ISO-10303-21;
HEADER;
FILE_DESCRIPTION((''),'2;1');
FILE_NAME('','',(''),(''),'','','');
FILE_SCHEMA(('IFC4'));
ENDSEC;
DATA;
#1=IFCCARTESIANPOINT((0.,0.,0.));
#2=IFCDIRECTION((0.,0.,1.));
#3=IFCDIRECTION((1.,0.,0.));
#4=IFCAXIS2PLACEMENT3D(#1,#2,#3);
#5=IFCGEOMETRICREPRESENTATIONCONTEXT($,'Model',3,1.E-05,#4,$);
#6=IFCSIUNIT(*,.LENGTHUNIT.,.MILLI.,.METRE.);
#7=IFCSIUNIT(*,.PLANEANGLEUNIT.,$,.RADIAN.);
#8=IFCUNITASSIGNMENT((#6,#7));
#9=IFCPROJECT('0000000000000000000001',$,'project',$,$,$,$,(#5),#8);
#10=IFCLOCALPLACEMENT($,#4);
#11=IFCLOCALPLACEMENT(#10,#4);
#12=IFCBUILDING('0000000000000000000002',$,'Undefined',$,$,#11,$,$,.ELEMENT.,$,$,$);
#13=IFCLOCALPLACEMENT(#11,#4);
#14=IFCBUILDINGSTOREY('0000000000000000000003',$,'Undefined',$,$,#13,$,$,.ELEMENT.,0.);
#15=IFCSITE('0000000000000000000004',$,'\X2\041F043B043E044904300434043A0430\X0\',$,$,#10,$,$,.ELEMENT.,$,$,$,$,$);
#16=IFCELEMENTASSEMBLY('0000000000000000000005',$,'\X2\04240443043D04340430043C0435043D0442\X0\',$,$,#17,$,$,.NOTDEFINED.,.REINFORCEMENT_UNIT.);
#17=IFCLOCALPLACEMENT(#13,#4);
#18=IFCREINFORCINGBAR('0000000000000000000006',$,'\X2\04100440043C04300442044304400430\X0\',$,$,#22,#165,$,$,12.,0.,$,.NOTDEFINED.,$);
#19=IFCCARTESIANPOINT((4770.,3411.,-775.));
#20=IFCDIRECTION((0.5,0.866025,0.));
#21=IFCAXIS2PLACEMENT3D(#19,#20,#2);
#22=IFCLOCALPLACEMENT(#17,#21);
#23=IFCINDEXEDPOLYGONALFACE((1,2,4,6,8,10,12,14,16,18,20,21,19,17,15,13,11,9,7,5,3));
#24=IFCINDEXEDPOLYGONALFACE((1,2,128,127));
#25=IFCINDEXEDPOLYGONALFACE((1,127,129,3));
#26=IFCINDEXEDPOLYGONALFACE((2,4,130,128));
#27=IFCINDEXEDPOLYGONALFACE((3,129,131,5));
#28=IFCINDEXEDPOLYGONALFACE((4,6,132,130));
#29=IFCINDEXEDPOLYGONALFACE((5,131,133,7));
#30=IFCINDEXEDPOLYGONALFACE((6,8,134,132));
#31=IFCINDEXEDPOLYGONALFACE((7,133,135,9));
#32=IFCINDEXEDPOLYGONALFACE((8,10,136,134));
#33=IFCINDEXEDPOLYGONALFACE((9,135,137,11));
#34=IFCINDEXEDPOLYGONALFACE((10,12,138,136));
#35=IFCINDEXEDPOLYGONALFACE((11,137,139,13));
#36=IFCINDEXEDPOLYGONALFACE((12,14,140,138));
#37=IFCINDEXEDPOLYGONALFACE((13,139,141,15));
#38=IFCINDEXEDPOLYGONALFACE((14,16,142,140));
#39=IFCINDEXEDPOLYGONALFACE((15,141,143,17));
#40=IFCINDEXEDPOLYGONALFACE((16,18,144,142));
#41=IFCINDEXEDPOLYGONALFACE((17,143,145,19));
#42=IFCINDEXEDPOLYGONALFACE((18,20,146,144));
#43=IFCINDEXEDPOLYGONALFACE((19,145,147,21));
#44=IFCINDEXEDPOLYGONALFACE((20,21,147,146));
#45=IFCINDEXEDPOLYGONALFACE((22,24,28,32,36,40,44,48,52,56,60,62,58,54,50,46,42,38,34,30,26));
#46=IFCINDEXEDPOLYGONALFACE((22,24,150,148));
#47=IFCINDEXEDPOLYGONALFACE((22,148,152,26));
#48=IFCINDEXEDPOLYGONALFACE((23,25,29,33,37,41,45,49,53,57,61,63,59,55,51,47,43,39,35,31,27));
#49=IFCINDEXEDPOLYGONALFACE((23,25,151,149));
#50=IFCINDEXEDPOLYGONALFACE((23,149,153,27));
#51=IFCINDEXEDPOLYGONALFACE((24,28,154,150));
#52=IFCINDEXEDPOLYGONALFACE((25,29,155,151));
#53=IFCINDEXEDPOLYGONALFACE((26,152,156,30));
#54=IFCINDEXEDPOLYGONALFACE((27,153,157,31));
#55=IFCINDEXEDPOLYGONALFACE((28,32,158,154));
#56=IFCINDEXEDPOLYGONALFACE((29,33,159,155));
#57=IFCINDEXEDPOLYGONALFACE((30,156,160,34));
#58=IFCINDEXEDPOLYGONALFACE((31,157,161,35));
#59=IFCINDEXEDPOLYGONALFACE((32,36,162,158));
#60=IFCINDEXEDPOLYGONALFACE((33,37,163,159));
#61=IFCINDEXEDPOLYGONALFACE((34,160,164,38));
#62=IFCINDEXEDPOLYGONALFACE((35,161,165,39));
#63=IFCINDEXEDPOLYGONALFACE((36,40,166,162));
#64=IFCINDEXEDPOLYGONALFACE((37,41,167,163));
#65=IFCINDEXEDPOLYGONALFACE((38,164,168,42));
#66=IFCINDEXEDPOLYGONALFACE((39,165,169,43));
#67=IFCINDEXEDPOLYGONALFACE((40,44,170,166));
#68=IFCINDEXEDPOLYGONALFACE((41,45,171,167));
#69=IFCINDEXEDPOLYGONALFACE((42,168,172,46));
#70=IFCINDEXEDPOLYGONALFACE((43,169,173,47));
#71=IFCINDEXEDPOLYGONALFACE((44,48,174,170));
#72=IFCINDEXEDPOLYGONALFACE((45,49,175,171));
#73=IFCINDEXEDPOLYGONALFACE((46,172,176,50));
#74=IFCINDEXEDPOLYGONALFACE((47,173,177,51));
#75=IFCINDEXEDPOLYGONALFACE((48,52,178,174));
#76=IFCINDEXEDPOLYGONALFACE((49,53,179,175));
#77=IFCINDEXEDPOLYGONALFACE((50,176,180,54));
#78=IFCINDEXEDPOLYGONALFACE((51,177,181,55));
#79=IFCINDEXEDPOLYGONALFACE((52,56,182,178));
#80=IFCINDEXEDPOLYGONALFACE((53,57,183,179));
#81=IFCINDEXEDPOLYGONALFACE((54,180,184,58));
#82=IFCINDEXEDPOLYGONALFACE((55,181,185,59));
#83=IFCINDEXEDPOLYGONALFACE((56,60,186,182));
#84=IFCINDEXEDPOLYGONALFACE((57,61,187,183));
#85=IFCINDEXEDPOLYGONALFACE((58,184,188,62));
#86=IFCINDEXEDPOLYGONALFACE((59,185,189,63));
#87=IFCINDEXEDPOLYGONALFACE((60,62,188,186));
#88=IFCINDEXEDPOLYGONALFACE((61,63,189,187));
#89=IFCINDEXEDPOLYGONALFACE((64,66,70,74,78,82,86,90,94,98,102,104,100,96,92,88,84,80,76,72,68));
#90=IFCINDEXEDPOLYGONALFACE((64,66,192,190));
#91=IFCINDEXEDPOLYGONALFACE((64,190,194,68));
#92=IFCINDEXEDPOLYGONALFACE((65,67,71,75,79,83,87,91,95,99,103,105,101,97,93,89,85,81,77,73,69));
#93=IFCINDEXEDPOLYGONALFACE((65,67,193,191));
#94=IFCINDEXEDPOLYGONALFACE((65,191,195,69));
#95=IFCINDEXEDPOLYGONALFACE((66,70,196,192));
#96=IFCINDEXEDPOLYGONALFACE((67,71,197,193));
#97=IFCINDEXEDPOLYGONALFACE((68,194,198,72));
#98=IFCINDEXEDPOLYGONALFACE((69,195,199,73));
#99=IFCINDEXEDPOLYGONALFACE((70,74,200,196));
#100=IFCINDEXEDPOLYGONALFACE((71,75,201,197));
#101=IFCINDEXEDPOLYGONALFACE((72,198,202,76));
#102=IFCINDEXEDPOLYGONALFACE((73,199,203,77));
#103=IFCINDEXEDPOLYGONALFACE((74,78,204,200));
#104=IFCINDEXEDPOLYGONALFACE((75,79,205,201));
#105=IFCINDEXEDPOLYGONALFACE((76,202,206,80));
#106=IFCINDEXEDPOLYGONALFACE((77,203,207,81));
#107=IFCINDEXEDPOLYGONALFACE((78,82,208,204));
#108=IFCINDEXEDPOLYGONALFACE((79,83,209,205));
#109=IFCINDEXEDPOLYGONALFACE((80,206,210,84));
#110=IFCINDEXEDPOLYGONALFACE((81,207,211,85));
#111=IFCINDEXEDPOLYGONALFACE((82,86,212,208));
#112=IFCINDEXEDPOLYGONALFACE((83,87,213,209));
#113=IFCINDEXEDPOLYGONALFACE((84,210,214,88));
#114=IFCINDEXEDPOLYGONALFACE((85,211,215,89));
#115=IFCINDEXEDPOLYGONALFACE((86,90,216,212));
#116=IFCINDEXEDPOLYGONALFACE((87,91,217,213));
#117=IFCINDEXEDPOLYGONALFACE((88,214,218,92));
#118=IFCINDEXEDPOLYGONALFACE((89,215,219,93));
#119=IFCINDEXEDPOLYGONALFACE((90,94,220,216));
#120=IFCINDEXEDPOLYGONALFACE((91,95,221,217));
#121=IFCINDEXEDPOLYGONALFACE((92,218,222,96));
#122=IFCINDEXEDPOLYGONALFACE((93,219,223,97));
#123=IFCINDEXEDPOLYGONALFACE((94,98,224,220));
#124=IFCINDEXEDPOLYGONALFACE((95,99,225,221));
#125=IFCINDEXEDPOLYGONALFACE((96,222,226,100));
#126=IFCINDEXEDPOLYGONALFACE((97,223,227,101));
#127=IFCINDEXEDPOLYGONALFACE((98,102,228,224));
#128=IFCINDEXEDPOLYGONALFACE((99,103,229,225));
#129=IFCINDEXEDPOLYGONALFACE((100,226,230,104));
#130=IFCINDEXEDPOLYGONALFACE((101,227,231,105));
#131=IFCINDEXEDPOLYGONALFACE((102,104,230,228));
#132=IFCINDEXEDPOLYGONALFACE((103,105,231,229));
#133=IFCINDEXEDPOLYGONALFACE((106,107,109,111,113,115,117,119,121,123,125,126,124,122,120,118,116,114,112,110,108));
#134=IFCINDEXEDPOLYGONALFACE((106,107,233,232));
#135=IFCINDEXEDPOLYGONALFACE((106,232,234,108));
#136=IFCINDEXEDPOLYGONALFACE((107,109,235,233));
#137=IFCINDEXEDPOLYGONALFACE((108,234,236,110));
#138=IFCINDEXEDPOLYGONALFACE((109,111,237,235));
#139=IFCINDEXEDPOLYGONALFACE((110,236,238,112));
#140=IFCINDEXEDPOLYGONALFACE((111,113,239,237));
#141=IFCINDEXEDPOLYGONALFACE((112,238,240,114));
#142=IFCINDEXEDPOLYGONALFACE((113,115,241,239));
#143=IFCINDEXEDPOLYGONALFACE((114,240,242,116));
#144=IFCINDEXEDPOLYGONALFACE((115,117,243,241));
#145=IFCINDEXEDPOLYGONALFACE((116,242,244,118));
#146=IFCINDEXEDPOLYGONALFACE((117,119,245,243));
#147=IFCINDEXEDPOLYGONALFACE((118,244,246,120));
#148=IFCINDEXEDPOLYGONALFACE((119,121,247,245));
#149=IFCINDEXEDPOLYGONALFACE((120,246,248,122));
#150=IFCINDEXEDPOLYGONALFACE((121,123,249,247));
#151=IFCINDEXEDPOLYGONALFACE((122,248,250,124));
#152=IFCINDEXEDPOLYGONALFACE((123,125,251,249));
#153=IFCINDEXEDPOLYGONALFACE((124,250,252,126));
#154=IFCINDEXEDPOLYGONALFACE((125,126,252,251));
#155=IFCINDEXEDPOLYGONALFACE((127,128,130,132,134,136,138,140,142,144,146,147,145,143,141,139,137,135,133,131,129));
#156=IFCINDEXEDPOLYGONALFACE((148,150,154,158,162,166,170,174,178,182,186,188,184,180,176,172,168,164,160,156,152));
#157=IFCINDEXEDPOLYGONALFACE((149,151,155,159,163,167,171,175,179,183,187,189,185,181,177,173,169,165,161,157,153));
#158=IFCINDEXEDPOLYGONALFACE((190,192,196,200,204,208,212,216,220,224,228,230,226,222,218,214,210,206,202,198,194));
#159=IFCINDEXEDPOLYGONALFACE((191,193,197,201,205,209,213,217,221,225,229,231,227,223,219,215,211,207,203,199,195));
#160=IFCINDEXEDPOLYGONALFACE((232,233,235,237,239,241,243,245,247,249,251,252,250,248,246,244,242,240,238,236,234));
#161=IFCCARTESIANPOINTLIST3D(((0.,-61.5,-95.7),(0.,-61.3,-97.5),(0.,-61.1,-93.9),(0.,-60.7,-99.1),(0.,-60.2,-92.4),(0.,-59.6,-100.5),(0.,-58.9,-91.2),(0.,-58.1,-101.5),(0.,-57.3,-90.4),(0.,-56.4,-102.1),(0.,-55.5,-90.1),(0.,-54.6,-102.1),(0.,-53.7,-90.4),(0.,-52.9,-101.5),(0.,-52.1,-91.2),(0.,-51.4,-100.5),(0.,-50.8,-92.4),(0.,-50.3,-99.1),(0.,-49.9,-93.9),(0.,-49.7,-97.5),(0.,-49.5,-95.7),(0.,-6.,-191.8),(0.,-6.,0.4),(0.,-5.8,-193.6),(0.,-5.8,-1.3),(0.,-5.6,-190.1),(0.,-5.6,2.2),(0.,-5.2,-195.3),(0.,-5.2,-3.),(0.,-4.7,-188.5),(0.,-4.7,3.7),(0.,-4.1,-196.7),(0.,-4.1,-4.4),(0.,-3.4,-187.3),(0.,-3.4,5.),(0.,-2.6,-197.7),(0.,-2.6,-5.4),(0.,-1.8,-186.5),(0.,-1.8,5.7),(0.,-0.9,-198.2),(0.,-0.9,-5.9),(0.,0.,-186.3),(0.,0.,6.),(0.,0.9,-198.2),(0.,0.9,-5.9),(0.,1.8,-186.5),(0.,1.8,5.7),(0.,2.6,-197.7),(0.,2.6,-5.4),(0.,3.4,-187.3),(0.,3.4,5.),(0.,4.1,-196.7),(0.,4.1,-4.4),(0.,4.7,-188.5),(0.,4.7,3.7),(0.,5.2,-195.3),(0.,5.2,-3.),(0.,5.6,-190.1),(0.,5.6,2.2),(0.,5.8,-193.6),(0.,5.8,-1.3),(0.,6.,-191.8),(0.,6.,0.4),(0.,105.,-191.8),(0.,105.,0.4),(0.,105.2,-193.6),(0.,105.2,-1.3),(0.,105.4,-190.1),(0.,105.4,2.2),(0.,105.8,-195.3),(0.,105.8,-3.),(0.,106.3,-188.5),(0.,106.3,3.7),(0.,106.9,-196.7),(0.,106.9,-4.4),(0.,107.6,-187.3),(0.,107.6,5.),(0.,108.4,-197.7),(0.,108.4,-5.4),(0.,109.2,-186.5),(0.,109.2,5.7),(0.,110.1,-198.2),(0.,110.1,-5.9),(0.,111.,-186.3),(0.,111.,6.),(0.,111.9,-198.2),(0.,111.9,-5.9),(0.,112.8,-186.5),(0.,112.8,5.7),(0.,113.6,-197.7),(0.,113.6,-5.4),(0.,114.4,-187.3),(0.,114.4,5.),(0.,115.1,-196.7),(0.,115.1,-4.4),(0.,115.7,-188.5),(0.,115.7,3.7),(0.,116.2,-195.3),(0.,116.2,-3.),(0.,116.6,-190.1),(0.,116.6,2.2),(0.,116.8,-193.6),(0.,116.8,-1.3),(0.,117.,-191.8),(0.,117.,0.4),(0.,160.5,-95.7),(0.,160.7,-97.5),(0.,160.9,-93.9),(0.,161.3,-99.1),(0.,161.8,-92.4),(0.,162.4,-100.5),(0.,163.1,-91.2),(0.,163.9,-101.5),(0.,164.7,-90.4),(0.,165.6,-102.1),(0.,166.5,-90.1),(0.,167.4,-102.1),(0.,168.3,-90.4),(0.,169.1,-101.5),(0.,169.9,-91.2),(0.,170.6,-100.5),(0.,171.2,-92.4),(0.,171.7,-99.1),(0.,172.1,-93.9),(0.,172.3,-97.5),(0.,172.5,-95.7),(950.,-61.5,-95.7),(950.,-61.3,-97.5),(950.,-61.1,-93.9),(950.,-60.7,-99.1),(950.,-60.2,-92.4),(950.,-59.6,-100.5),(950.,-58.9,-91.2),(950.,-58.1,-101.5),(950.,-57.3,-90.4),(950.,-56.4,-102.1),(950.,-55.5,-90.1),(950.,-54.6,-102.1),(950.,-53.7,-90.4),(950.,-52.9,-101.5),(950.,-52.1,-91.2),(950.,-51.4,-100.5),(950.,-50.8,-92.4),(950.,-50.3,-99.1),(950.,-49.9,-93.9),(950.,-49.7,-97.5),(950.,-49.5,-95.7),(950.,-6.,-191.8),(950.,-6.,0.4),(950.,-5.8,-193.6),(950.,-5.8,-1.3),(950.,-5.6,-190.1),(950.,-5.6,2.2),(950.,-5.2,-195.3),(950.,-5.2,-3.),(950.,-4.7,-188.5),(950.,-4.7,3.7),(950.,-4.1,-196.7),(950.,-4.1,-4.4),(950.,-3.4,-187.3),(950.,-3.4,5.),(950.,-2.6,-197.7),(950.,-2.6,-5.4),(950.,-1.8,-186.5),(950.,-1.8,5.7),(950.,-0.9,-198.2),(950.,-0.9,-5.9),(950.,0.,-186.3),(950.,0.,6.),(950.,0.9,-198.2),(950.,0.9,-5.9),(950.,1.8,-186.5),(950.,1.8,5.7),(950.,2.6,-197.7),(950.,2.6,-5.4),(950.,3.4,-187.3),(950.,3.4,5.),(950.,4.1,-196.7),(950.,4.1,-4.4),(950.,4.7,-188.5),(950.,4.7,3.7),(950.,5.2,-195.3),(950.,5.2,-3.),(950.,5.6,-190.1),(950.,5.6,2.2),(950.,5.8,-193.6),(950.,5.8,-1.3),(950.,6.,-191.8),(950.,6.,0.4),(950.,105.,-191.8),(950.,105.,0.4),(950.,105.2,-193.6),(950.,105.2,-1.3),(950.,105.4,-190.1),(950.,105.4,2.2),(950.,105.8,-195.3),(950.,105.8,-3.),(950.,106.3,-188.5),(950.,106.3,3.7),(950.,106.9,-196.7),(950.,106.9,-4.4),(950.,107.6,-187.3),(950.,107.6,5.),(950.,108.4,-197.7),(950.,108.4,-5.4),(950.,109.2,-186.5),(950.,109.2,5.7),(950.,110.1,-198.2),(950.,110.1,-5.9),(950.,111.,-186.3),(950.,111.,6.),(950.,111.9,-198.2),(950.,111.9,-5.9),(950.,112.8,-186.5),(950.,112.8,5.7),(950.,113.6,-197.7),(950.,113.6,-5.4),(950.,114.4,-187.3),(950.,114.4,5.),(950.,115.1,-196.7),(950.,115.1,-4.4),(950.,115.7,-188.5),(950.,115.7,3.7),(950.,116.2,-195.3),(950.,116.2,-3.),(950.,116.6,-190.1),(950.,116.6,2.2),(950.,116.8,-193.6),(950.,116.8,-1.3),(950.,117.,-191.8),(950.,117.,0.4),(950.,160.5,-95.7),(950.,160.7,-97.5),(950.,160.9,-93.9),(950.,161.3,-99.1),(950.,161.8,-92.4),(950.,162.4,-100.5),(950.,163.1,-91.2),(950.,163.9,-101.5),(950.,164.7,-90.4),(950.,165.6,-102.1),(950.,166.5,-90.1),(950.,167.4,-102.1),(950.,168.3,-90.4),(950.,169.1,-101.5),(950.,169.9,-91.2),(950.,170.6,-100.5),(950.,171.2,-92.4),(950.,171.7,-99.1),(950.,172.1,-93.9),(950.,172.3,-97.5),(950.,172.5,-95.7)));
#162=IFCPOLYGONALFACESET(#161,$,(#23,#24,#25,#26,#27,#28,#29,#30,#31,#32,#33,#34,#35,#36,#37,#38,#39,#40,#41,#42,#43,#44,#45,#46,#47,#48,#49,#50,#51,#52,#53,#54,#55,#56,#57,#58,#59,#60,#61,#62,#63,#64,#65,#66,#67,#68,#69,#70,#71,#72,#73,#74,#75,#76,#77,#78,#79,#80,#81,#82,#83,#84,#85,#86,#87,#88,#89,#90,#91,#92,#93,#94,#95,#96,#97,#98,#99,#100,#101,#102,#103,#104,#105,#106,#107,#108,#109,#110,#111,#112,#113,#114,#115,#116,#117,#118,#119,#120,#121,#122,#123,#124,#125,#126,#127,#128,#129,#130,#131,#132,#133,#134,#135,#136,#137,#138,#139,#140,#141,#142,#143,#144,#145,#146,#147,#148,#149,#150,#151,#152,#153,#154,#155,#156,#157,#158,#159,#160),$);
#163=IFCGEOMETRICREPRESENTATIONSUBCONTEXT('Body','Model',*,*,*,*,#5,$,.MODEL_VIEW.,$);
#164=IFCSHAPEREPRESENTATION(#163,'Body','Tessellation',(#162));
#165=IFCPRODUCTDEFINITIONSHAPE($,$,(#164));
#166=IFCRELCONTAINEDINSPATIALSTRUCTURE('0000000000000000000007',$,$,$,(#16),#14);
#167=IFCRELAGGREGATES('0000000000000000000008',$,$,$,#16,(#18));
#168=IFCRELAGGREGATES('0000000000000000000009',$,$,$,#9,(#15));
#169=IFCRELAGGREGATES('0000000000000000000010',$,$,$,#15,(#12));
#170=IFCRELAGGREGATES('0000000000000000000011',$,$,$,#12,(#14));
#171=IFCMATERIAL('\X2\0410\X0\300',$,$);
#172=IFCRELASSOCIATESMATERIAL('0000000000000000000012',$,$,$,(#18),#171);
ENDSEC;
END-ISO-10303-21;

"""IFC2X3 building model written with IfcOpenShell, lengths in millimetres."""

from ifc_helpers import new_model, entity, si_unit, frame, origin_with_axes, place, context, subcontext, project, spatial, source, transform, mapped, material, element, aggregate, save


model = new_model("IFC2X3")

# Units and contexts
model_context = context("Model", 3, precision=1e-05, world=origin_with_axes())
body_context = subcontext(model_context, "Body", "Model", "MODEL_VIEW")
ifc_project = project(units=[si_unit("LENGTHUNIT", "METRE", prefix="MILLI"), si_unit("PLANEANGLEUNIT", "RADIAN")], contexts=[model_context])

# Site, building, storey
site_placement = place(None, origin_with_axes())
site = spatial("IfcSite", under=ifc_project, at=site_placement, Name="Площадка", CompositionType="ELEMENT")
building_placement = place(site_placement, origin_with_axes())
building = spatial("IfcBuilding", under=site, at=building_placement, Name="Undefined", CompositionType="ELEMENT")
storey_placement = place(building_placement, origin_with_axes())
storey = spatial("IfcBuildingStorey", under=building, at=storey_placement, Name="Undefined", CompositionType="ELEMENT", Elevation=0.0)

# Element assembly
assembly_1_placement = place(storey_placement, origin_with_axes())
assembly_1 = element("IfcElementAssembly", 1, at=assembly_1_placement, inside=storey, Name="Фундамент", AssemblyPlace="NOTDEFINED", PredefinedType="REINFORCEMENT_UNIT")

# Reinforcing bar
ifc_material_1 = material(Name="А300")
shared_shape_1 = source(origin_with_axes(), body_context, "Body", "AdvancedSweptSolid", [
    entity("IfcSweptDiskSolid", entity("IfcTrimmedCurve", entity("IfcLine", entity("IfcCartesianPoint", [0.0, 0.0, 0.0]), entity("IfcVector", entity("IfcDirection", [1.0, 0.0, 0.0]), 1.0)), [entity("IfcParameterValue", 0.0)], [entity("IfcParameterValue", 950.0)], True, "PARAMETER"), 6.0, None, 0.0, 950.0),
])
shared_shape_2 = source(origin_with_axes(), body_context, "Body", "AdvancedSweptSolid", [
    entity("IfcSweptDiskSolid", entity("IfcTrimmedCurve", entity("IfcLine", entity("IfcCartesianPoint", [0.0, 0.0, 0.0]), entity("IfcVector", entity("IfcDirection", [1.0, 0.0, 0.0]), 1.0)), [entity("IfcParameterValue", 0.0)], [entity("IfcParameterValue", 950.0)], True, "PARAMETER"), 6.0, None, 0.0, 950.0),
])
shared_shape_3 = source(origin_with_axes(), body_context, "Body", "AdvancedSweptSolid", [
    entity("IfcSweptDiskSolid", entity("IfcTrimmedCurve", entity("IfcLine", entity("IfcCartesianPoint", [0.0, 0.0, 0.0]), entity("IfcVector", entity("IfcDirection", [1.0, 0.0, 0.0]), 1.0)), [entity("IfcParameterValue", 0.0)], [entity("IfcParameterValue", 950.0)], True, "PARAMETER"), 6.0, None, 0.0, 950.0),
])
shared_shape_4 = source(origin_with_axes(), body_context, "Body", "AdvancedSweptSolid", [
    entity("IfcSweptDiskSolid", entity("IfcTrimmedCurve", entity("IfcLine", entity("IfcCartesianPoint", [0.0, 0.0, 0.0]), entity("IfcVector", entity("IfcDirection", [1.0, 0.0, 0.0]), 1.0)), [entity("IfcParameterValue", 0.0)], [entity("IfcParameterValue", 950.0)], True, "PARAMETER"), 6.0, None, 0.0, 950.0),
])
shared_shape_5 = source(origin_with_axes(), body_context, "Body", "AdvancedSweptSolid", [
    entity("IfcSweptDiskSolid", entity("IfcTrimmedCurve", entity("IfcLine", entity("IfcCartesianPoint", [0.0, 0.0, 0.0]), entity("IfcVector", entity("IfcDirection", [1.0, 0.0, 0.0]), 1.0)), [entity("IfcParameterValue", 0.0)], [entity("IfcParameterValue", 950.0)], True, "PARAMETER"), 6.0, None, 0.0, 950.0),
])
shared_shape_6 = source(origin_with_axes(), body_context, "Body", "AdvancedSweptSolid", [
    entity("IfcSweptDiskSolid", entity("IfcTrimmedCurve", entity("IfcLine", entity("IfcCartesianPoint", [0.0, 0.0, 0.0]), entity("IfcVector", entity("IfcDirection", [1.0, 0.0, 0.0]), 1.0)), [entity("IfcParameterValue", 0.0)], [entity("IfcParameterValue", 950.0)], True, "PARAMETER"), 6.0, None, 0.0, 950.0),
])
reinforcing_bar_1_placement = place(assembly_1_placement, frame((4770.0, 3411.0, -775.0), z_axis=(0.5, 0.866025, 0.0), x_axis=(0.0, 0.0, 1.0)))
reinforcing_bar_1 = element("IfcReinforcingBar", 2, at=reinforcing_bar_1_placement, material=ifc_material_1, Name="Арматура", BarRole="NOTDEFINED", CrossSectionArea=0.0, NominalDiameter=12.0, context=body_context, shape_type="MappedRepresentation", body=[
    mapped(shared_shape_1, transform((0.0, 0.0, 0.0))),
    mapped(shared_shape_2, transform((0.0, -55.5, -96.1))),
    mapped(shared_shape_3, transform((0.0, 0.0, -192.3))),
    mapped(shared_shape_4, transform((0.0, 111.0, -192.3))),
    mapped(shared_shape_5, transform((0.0, 166.5, -96.1))),
    mapped(shared_shape_6, transform((0.0, 111.0, 0.0))),
])
aggregate(assembly_1, [reinforcing_bar_1])

save(model, "model.ifc")
